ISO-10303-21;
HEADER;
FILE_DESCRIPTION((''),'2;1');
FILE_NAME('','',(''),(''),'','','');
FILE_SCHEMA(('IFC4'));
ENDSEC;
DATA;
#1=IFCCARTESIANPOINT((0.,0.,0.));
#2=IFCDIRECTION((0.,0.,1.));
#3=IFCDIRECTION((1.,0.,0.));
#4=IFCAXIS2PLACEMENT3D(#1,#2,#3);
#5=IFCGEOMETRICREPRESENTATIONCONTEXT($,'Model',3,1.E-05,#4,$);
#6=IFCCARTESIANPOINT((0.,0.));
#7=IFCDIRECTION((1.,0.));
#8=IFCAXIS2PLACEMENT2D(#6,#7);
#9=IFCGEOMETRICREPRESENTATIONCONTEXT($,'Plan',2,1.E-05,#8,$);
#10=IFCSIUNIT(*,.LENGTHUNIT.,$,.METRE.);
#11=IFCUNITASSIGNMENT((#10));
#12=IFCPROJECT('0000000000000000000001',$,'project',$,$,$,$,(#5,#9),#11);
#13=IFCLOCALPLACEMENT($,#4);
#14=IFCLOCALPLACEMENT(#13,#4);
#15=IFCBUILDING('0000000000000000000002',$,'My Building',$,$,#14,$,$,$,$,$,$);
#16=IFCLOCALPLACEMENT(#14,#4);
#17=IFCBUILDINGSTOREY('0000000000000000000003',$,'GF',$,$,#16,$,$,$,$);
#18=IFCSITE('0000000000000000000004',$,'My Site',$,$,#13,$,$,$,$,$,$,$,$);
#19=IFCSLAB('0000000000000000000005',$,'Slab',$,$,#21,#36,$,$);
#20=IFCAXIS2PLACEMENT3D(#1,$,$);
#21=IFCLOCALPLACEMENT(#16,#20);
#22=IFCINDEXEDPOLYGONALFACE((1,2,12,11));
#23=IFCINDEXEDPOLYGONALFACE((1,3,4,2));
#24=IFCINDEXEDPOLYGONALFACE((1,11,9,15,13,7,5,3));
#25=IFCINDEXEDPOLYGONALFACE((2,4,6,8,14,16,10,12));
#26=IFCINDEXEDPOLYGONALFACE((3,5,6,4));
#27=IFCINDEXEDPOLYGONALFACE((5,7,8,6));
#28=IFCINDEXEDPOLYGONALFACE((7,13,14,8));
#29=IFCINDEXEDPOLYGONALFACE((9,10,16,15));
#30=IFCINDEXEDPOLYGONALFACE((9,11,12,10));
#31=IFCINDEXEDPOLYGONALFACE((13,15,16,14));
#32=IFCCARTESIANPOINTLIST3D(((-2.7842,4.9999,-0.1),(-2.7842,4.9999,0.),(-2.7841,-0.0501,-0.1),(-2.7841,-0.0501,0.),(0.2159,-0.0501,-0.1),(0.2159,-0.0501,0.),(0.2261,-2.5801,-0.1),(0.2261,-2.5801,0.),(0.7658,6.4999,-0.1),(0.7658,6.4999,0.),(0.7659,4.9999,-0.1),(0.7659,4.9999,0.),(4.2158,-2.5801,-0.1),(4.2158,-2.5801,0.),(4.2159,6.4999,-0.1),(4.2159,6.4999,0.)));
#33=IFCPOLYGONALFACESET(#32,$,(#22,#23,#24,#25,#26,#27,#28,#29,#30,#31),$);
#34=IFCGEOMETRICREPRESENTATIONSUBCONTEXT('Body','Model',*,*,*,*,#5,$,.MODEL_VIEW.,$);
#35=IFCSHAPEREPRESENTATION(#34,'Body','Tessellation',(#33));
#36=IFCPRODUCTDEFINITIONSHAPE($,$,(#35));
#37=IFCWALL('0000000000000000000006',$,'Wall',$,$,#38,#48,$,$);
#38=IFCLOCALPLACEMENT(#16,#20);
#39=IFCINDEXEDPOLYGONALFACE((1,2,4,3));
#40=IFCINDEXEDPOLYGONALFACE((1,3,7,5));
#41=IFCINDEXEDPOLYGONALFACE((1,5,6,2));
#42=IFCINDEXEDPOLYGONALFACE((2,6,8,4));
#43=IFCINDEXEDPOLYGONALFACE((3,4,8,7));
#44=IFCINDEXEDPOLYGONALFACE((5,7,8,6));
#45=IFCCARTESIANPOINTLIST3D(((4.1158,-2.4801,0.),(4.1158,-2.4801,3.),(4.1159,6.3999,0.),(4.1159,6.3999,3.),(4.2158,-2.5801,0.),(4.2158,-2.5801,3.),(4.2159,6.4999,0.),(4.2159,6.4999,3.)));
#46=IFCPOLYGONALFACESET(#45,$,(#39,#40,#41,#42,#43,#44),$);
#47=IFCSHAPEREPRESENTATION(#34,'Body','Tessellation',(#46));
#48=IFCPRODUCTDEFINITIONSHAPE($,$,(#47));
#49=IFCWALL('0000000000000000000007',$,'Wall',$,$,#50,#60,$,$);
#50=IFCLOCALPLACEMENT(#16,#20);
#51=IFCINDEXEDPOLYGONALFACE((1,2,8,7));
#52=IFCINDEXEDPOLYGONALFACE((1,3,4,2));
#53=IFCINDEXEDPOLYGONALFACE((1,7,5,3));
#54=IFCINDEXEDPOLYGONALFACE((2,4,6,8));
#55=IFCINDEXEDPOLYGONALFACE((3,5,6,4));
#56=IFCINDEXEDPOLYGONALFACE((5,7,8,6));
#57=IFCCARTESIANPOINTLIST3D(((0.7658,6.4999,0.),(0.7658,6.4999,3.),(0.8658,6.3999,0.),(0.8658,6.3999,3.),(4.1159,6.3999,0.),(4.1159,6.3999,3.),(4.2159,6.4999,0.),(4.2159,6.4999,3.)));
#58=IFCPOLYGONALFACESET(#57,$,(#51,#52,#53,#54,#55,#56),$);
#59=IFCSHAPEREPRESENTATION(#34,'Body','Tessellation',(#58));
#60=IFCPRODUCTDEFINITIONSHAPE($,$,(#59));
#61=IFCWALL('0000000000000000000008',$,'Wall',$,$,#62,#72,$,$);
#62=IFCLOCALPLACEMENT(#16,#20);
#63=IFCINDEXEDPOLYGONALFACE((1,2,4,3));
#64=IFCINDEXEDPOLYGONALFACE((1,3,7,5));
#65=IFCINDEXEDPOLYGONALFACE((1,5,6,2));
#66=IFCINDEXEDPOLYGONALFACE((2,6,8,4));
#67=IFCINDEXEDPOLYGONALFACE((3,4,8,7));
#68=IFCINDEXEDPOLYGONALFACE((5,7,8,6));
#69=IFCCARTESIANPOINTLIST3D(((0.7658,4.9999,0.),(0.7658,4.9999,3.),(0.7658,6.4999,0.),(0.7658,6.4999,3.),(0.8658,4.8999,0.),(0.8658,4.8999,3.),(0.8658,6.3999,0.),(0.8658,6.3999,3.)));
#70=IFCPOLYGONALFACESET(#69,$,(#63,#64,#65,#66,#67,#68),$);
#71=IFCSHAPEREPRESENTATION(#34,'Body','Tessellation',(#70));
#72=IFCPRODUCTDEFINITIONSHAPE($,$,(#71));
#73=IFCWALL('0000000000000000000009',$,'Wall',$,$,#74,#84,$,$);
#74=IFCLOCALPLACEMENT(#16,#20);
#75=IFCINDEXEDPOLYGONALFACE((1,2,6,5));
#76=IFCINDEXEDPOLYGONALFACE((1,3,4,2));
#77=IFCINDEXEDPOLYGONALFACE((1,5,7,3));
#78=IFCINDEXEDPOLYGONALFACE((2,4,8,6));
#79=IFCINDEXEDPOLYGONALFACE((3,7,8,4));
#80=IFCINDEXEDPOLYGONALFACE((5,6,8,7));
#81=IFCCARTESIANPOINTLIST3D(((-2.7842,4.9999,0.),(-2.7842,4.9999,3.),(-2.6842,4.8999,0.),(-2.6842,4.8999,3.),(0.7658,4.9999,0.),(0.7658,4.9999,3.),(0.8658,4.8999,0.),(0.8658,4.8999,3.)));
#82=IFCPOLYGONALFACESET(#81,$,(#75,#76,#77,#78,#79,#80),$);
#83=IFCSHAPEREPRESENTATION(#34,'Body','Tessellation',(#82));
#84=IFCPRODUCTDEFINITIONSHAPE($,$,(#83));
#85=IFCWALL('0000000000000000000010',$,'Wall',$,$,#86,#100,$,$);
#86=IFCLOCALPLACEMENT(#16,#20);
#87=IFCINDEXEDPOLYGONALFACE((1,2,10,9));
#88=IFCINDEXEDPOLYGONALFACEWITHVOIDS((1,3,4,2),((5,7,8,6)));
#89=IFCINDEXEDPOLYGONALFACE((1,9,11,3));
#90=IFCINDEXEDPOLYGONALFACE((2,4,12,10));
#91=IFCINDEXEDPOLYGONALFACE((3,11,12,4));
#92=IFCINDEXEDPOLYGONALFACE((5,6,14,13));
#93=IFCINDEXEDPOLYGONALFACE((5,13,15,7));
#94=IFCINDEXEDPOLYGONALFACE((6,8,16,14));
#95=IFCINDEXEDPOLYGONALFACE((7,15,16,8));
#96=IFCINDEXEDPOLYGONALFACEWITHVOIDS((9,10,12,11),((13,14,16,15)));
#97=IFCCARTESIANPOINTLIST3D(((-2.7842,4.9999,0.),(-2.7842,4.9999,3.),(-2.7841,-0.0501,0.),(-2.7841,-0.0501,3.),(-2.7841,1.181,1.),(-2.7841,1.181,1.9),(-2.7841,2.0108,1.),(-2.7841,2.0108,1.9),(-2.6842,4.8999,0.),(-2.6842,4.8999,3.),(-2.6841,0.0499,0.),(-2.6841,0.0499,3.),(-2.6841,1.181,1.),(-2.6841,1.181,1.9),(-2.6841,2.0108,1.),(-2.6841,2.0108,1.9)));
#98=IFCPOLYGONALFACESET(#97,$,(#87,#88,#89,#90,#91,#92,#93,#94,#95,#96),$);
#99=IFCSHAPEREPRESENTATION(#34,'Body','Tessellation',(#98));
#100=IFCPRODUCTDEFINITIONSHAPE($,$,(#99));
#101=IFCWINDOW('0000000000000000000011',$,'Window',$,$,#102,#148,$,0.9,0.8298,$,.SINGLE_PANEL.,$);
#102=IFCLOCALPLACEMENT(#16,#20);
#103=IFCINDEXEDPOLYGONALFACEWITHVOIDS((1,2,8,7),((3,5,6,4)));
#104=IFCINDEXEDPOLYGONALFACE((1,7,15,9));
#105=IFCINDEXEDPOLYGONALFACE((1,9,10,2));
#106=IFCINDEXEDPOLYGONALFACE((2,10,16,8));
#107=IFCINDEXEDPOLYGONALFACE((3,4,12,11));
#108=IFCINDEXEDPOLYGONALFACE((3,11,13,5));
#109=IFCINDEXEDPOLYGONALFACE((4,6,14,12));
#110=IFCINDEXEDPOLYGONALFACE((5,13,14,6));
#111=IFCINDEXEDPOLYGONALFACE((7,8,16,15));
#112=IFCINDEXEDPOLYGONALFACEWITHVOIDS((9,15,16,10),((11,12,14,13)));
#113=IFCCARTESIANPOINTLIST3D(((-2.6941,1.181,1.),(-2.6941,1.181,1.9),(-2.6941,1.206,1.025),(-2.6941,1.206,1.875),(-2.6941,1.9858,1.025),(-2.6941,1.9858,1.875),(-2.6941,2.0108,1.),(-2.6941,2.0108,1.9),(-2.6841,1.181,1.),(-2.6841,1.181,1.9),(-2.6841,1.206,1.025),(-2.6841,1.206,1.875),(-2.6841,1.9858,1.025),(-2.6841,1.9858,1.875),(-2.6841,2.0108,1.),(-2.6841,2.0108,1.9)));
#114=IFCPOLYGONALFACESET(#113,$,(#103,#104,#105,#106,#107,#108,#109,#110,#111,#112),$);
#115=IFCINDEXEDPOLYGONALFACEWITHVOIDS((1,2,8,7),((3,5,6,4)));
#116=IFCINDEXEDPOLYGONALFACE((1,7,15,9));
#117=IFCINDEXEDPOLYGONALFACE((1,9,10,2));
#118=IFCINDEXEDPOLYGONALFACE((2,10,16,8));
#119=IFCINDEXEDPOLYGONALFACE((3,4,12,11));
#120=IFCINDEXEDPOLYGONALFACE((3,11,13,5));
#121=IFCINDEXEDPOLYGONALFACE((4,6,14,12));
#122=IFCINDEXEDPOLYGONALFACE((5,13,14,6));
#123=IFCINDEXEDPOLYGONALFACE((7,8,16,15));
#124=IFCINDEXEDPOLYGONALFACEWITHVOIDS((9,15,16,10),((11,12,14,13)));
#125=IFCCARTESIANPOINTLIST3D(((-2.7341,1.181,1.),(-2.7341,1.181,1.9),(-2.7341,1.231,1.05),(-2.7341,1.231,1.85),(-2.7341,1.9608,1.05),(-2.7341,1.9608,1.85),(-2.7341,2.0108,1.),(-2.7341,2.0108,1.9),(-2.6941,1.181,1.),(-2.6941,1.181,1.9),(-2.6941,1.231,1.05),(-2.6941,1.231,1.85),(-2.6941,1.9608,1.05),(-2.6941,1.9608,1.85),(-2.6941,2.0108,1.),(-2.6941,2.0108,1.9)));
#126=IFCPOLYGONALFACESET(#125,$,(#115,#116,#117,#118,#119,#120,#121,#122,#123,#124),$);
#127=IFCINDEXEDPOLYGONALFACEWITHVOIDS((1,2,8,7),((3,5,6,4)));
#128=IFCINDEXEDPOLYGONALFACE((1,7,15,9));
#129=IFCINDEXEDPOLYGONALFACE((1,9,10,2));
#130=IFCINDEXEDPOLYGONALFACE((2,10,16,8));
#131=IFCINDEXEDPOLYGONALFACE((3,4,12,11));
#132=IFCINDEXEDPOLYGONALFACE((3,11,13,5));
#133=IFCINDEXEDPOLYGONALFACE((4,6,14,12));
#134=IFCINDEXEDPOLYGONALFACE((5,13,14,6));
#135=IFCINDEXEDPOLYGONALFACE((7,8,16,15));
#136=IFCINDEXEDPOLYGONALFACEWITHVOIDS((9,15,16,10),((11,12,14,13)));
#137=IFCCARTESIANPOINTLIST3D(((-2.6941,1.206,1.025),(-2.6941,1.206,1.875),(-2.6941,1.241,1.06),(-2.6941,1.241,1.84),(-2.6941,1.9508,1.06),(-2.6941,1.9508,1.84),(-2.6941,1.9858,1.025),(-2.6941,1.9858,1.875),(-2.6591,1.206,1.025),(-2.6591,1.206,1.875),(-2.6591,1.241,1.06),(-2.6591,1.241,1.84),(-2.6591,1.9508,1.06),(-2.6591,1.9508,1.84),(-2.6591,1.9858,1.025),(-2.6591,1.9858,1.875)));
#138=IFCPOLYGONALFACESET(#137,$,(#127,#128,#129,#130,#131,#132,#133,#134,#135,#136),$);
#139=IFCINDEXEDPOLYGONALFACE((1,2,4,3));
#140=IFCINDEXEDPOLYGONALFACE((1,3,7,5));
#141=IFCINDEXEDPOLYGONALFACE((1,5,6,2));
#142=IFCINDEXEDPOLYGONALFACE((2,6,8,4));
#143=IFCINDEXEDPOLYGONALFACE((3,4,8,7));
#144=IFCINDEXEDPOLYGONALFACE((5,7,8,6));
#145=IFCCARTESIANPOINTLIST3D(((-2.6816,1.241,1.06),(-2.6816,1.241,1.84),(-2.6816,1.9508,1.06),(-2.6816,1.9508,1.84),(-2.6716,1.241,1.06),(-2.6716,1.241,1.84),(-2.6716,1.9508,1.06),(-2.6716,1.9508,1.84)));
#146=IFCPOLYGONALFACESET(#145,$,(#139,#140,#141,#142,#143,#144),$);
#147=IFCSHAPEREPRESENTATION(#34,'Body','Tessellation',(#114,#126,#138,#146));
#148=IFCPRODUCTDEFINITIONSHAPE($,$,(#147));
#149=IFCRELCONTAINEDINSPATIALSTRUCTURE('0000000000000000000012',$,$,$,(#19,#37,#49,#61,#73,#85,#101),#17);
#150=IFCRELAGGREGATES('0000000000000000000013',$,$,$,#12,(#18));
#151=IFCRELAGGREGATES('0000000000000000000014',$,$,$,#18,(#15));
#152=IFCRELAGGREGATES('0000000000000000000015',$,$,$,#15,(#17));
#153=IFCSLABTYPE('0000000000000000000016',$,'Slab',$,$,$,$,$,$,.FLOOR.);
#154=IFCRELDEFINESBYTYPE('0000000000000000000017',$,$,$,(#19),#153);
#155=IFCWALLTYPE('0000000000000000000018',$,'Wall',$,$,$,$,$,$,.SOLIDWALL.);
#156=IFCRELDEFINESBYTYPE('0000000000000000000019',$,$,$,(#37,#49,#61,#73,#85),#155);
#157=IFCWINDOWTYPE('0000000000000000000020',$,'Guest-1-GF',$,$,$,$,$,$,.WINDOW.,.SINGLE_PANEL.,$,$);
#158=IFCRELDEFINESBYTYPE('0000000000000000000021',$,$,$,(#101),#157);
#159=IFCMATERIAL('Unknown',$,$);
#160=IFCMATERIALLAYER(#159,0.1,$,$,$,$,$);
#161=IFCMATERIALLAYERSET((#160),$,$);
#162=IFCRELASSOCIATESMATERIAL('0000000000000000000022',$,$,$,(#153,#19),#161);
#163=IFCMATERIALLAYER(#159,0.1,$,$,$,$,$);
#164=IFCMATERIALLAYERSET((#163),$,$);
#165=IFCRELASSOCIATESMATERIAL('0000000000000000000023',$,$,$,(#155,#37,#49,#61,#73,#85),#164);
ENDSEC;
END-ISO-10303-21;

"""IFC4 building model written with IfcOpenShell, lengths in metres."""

from ifc_helpers import new_model, entity, si_unit, frame, origin_with_axes, origin_2d_with_axis, place, context, subcontext, project, spatial, line, indexed_curve, outline, extrude, shape, source, transform, mapped, material, layer, layer_set, layer_usage, type_object, type_shapes, element, fill, save


model = new_model("IFC4")

# Units and contexts
model_context = context("Model", 3, precision=1e-05, world=origin_with_axes())
plan_context = context("Plan", 2, precision=1e-05, world=origin_2d_with_axis())
body_context_1 = subcontext(model_context, "Body", "Model", "MODEL_VIEW")
body_context_2 = subcontext(plan_context, "Body", "Plan", "PLAN_VIEW")
ifc_project = project(units=[si_unit("LENGTHUNIT", "METRE")], contexts=[model_context, plan_context])

# Site, building, storey
site_placement = place(None, origin_with_axes())
site = spatial("IfcSite", under=ifc_project, at=site_placement, Name="My Site")
building_placement = place(site_placement, origin_with_axes())
building = spatial("IfcBuilding", under=site, at=building_placement, Name="My Building")
storey_placement = place(building_placement, origin_with_axes())
storey = spatial("IfcBuildingStorey", under=building, at=storey_placement, Name="GF")

# Slab
ifc_material = material(Name="Unknown")
ifc_layer_1 = layer(ifc_material, 0.1)
ifc_layer_set_1 = layer_set([ifc_layer_1])
ifc_layer_usage_1 = layer_usage(ifc_layer_set_1, "AXIS3", "POSITIVE", -0.1)
slab_type = type_object("IfcSlabType", Name="Slab", PredefinedType="FLOOR", material=ifc_layer_set_1)
slab_placement = place(storey_placement, frame((0.2261, -2.5801, 0.0), z_axis=(0.0, 0.0, 1.0), x_axis=(1.0, 0.0, 0.0)))
element("IfcSlab", 1, at=slab_placement, inside=storey, type_object=slab_type, material=ifc_layer_usage_1, Name="Slab", context=body_context_1, shape_type="SweptSolid", body=[
    extrude(outline(indexed_curve([(0.0, 0.0), (3.9897, 0.0), (3.9897, 9.08), (0.5397, 9.08), (0.5397, 7.58), (-3.0103, 7.58), (-3.0103, 2.53), (-0.0103, 2.53), (0.0, 0.0)])), frame((0.0, 0.0, -0.1), z_axis=(0.0, 0.0, 1.0), x_axis=(1.0, 0.0, 0.0)), (0.0, 0.0, 1.0), 0.1),
])

# Shared definitions
ifc_layer_2 = layer(ifc_material, 0.1)
ifc_layer_set_2 = layer_set([ifc_layer_2])
wall_type = type_object("IfcWallType", Name="Wall", PredefinedType="SOLIDWALL", material=ifc_layer_set_2)

# Walls
ifc_layer_usage_2 = layer_usage(ifc_layer_set_2, "AXIS2", "POSITIVE", 0.0)
wall_1_placement = place(storey_placement, frame((4.2158, -2.5801, 0.0), z_axis=(0.0, 0.0, 1.0), x_axis=(0.0, 1.0, 0.0)))
element("IfcWall", 2, at=wall_1_placement, inside=storey, type_object=wall_type, material=ifc_layer_usage_2, Name="Wall", context=body_context_1, shape_type="SweptSolid", body=[
    extrude(outline(indexed_curve([(0.0, 0.0), (0.1, 0.1), (8.98, 0.1), (9.08, 0.0)], segments=[line(1, 2, 3, 4, 1)])), origin_with_axes(), (0.0, 0.0, 1.0), 3.0),
])
ifc_layer_usage_3 = layer_usage(ifc_layer_set_2, "AXIS2", "POSITIVE", 0.0)
wall_2_placement = place(storey_placement, frame((4.2159, 6.4999, 0.0), z_axis=(0.0, 0.0, 1.0), x_axis=(-1.0, 0.0, 0.0)))
element("IfcWall", 3, at=wall_2_placement, inside=storey, type_object=wall_type, material=ifc_layer_usage_3, Name="Wall", context=body_context_1, shape_type="SweptSolid", body=[
    extrude(outline(indexed_curve([(0.0, 0.0), (0.1, 0.1), (3.35, 0.1), (3.45, 0.0)], segments=[line(1, 2, 3, 4, 1)])), origin_with_axes(), (0.0, 0.0, 1.0), 3.0),
])
ifc_layer_usage_4 = layer_usage(ifc_layer_set_2, "AXIS2", "POSITIVE", 0.0)
wall_3_placement = place(storey_placement, frame((0.7658, 6.4999, 0.0), z_axis=(0.0, 0.0, 1.0), x_axis=(0.0, -1.0, 0.0)))
element("IfcWall", 4, at=wall_3_placement, inside=storey, type_object=wall_type, material=ifc_layer_usage_4, Name="Wall", context=body_context_1, shape_type="SweptSolid", body=[
    extrude(outline(indexed_curve([(0.0, 0.0), (0.1, 0.1), (1.6, 0.1), (1.5, 0.0)], segments=[line(1, 2, 3, 4, 1)])), origin_with_axes(), (0.0, 0.0, 1.0), 3.0),
])
ifc_layer_usage_5 = layer_usage(ifc_layer_set_2, "AXIS2", "POSITIVE", 0.0)
wall_4_placement = place(storey_placement, frame((0.7658, 4.9999, 0.0), z_axis=(0.0, 0.0, 1.0), x_axis=(-1.0, 0.0, 0.0)))
element("IfcWall", 5, at=wall_4_placement, inside=storey, type_object=wall_type, material=ifc_layer_usage_5, Name="Wall", context=body_context_1, shape_type="SweptSolid", body=[
    extrude(outline(indexed_curve([(0.0, 0.0), (-0.1, 0.1), (3.45, 0.1), (3.55, 0.0)], segments=[line(1, 2, 3, 4, 1)])), origin_with_axes(), (0.0, 0.0, 1.0), 3.0),
])

# Wall, opening, window
ifc_layer_usage_6 = layer_usage(ifc_layer_set_2, "AXIS2", "POSITIVE", 0.0)
wall_5_placement = place(storey_placement, frame((-2.7842, 4.9999, 0.0), z_axis=(0.0, 0.0, 1.0), x_axis=(0.0, -1.0, 0.0)))
wall_5 = element("IfcWall", 6, at=wall_5_placement, inside=storey, type_object=wall_type, material=ifc_layer_usage_6, Name="Wall", context=body_context_1, shape_type="SweptSolid", body=[
    extrude(outline(indexed_curve([(0.0, 0.0), (0.1, 0.1), (4.95, 0.1), (5.05, 0.0)], segments=[line(1, 2, 3, 4, 1)])), origin_with_axes(), (0.0, 0.0, 1.0), 3.0),
])
shared_shape_1 = source(origin_with_axes(), body_context_1, "Body", "SweptSolid", [
    extrude(outline(indexed_curve([(0.0, 0.0), (0.8298, 0.0), (0.8298, 0.9), (0.0, 0.9)], segments=[line(1, 2, 3, 4, 1)])), frame((0.0, -0.6, 0.0), z_axis=(0.0, -1.0, 0.0), x_axis=(1.0, 0.0, 0.0)), (0.0, 0.0, -1.0), 1.2),
])
opening_1_placement = place(wall_5_placement, frame((2.989, 0.0, 1.0), z_axis=(0.0, 0.0, 1.0), x_axis=(1.0, 0.0, 0.0)))
opening_1 = element("IfcOpeningElement", 7, at=opening_1_placement, cuts=wall_5, PredefinedType="OPENING", context=body_context_1, shape_type="MappedRepresentation", body=[
    mapped(shared_shape_1, transform((0.0, 0.0, 0.0), x_axis=(1.0, 0.0, 0.0), y_axis=(0.0, 1.0, 0.0), z_axis=(0.0, 0.0, 1.0), scale=1.0)),
])
window_type_1 = type_object("IfcWindowType", Name="Guest-1-GF", PartitioningType="SINGLE_PANEL", PredefinedType="WINDOW")
shared_shape_2 = source(origin_with_axes(), body_context_1, "Body", "SweptSolid", [
    extrude(outline(indexed_curve([(0.0, 0.0), (0.8298, 0.0), (0.8298, 0.9), (0.0, 0.9)], segments=[line(1, 2, 3, 4, 1)]), holes=[indexed_curve([(0.025, 0.025), (0.8048, 0.025), (0.8048, 0.875), (0.025, 0.875)], segments=[line(1, 2, 3, 4, 1)])]), frame((0.0, 0.09, 0.0), z_axis=(0.0, -1.0, 0.0), x_axis=(1.0, 0.0, 0.0)), (0.0, 0.0, -1.0), 0.01),
    extrude(outline(indexed_curve([(0.0, 0.0), (0.8298, 0.0), (0.8298, 0.9), (0.0, 0.9)], segments=[line(1, 2, 3, 4, 1)]), holes=[indexed_curve([(0.05, 0.05), (0.7798, 0.05), (0.7798, 0.85), (0.05, 0.85)], segments=[line(1, 2, 3, 4, 1)])]), frame((0.0, 0.05, 0.0), z_axis=(0.0, -1.0, 0.0), x_axis=(1.0, 0.0, 0.0)), (0.0, 0.0, -1.0), 0.04),
    extrude(outline(indexed_curve([(0.0, 0.0), (0.7798, 0.0), (0.7798, 0.85), (0.0, 0.85)], segments=[line(1, 2, 3, 4, 1)]), holes=[indexed_curve([(0.035, 0.035), (0.7448, 0.035), (0.7448, 0.815), (0.035, 0.815)], segments=[line(1, 2, 3, 4, 1)])]), frame((0.025, 0.09, 0.025), z_axis=(0.0, -1.0, 0.0), x_axis=(1.0, 0.0, 0.0)), (0.0, 0.0, -1.0), 0.035),
    extrude(outline(indexed_curve([(0.035, 0.035), (0.7448, 0.035), (0.7448, 0.815), (0.035, 0.815)], segments=[line(1, 2, 3, 4, 1)])), frame((0.025, 0.1025, 0.025), z_axis=(0.0, -1.0, 0.0), x_axis=(1.0, 0.0, 0.0)), (0.0, 0.0, -1.0), 0.01),
])
shared_shape_3 = source(origin_with_axes(), body_context_2, "Body", "Curve2D", [
    entity("IfcIndexedPolyCurve", entity("IfcCartesianPointList2D", [[0.05, 0.05], [0.7798, 0.05]])),
    entity("IfcIndexedPolyCurve", entity("IfcCartesianPointList2D", [[0.0, 0.1], [0.025, 0.1], [0.025, 0.09], [0.05, 0.09], [0.05, 0.05], [0.0, 0.05]]), [entity("IfcLineIndex", [1, 2, 3, 4, 5, 6, 1])]),
    entity("IfcIndexedPolyCurve", entity("IfcCartesianPointList2D", [[0.8298, 0.1], [0.8048, 0.1], [0.8048, 0.09], [0.7798, 0.09], [0.7798, 0.05], [0.8298, 0.05]]), [entity("IfcLineIndex", [1, 2, 3, 4, 5, 6, 1])]),
    entity("IfcIndexedPolyCurve", entity("IfcCartesianPointList2D", [[0.025, 0.09], [0.06, 0.09], [0.06, 0.125], [0.025, 0.125]]), [entity("IfcLineIndex", [1, 2, 3, 4, 1])]),
    entity("IfcIndexedPolyCurve", entity("IfcCartesianPointList2D", [[0.8048, 0.09], [0.7698, 0.09], [0.7698, 0.125], [0.8048, 0.125]]), [entity("IfcLineIndex", [1, 2, 3, 4, 1])]),
    entity("IfcIndexedPolyCurve", entity("IfcCartesianPointList2D", [[0.06, 0.09], [0.7698, 0.09]])),
    entity("IfcIndexedPolyCurve", entity("IfcCartesianPointList2D", [[0.06, 0.125], [0.7698, 0.125]])),
    entity("IfcIndexedPolyCurve", entity("IfcCartesianPointList2D", [[0.06, 0.1075], [0.7698, 0.1075]])),
])
type_shapes(window_type_1, [shared_shape_2, shared_shape_3])
window_1_placement = place(opening_1_placement, frame((0.0, 0.0, 0.0), z_axis=(0.0, 0.0, 1.0), x_axis=(1.0, 0.0, 0.0)))
window_1 = element("IfcWindow", 8, at=window_1_placement, inside=storey, type_object=window_type_1, Name="Window", OverallHeight=0.9, OverallWidth=0.8298, PartitioningType="SINGLE_PANEL", shapes=[
    shape(body_context_1, "Body", "MappedRepresentation", [mapped(shared_shape_2, transform((0.0, 0.0, 0.0), x_axis=(1.0, 0.0, 0.0), y_axis=(0.0, 1.0, 0.0), z_axis=(0.0, 0.0, 1.0), scale=1.0))]),
    shape(body_context_2, "Body", "MappedRepresentation", [mapped(shared_shape_3, transform((0.0, 0.0, 0.0), x_axis=(1.0, 0.0, 0.0), y_axis=(0.0, 1.0, 0.0), z_axis=(0.0, 0.0, 1.0), scale=1.0))]),
])
fill(opening_1, window_1)

save(model, "model.ifc")
